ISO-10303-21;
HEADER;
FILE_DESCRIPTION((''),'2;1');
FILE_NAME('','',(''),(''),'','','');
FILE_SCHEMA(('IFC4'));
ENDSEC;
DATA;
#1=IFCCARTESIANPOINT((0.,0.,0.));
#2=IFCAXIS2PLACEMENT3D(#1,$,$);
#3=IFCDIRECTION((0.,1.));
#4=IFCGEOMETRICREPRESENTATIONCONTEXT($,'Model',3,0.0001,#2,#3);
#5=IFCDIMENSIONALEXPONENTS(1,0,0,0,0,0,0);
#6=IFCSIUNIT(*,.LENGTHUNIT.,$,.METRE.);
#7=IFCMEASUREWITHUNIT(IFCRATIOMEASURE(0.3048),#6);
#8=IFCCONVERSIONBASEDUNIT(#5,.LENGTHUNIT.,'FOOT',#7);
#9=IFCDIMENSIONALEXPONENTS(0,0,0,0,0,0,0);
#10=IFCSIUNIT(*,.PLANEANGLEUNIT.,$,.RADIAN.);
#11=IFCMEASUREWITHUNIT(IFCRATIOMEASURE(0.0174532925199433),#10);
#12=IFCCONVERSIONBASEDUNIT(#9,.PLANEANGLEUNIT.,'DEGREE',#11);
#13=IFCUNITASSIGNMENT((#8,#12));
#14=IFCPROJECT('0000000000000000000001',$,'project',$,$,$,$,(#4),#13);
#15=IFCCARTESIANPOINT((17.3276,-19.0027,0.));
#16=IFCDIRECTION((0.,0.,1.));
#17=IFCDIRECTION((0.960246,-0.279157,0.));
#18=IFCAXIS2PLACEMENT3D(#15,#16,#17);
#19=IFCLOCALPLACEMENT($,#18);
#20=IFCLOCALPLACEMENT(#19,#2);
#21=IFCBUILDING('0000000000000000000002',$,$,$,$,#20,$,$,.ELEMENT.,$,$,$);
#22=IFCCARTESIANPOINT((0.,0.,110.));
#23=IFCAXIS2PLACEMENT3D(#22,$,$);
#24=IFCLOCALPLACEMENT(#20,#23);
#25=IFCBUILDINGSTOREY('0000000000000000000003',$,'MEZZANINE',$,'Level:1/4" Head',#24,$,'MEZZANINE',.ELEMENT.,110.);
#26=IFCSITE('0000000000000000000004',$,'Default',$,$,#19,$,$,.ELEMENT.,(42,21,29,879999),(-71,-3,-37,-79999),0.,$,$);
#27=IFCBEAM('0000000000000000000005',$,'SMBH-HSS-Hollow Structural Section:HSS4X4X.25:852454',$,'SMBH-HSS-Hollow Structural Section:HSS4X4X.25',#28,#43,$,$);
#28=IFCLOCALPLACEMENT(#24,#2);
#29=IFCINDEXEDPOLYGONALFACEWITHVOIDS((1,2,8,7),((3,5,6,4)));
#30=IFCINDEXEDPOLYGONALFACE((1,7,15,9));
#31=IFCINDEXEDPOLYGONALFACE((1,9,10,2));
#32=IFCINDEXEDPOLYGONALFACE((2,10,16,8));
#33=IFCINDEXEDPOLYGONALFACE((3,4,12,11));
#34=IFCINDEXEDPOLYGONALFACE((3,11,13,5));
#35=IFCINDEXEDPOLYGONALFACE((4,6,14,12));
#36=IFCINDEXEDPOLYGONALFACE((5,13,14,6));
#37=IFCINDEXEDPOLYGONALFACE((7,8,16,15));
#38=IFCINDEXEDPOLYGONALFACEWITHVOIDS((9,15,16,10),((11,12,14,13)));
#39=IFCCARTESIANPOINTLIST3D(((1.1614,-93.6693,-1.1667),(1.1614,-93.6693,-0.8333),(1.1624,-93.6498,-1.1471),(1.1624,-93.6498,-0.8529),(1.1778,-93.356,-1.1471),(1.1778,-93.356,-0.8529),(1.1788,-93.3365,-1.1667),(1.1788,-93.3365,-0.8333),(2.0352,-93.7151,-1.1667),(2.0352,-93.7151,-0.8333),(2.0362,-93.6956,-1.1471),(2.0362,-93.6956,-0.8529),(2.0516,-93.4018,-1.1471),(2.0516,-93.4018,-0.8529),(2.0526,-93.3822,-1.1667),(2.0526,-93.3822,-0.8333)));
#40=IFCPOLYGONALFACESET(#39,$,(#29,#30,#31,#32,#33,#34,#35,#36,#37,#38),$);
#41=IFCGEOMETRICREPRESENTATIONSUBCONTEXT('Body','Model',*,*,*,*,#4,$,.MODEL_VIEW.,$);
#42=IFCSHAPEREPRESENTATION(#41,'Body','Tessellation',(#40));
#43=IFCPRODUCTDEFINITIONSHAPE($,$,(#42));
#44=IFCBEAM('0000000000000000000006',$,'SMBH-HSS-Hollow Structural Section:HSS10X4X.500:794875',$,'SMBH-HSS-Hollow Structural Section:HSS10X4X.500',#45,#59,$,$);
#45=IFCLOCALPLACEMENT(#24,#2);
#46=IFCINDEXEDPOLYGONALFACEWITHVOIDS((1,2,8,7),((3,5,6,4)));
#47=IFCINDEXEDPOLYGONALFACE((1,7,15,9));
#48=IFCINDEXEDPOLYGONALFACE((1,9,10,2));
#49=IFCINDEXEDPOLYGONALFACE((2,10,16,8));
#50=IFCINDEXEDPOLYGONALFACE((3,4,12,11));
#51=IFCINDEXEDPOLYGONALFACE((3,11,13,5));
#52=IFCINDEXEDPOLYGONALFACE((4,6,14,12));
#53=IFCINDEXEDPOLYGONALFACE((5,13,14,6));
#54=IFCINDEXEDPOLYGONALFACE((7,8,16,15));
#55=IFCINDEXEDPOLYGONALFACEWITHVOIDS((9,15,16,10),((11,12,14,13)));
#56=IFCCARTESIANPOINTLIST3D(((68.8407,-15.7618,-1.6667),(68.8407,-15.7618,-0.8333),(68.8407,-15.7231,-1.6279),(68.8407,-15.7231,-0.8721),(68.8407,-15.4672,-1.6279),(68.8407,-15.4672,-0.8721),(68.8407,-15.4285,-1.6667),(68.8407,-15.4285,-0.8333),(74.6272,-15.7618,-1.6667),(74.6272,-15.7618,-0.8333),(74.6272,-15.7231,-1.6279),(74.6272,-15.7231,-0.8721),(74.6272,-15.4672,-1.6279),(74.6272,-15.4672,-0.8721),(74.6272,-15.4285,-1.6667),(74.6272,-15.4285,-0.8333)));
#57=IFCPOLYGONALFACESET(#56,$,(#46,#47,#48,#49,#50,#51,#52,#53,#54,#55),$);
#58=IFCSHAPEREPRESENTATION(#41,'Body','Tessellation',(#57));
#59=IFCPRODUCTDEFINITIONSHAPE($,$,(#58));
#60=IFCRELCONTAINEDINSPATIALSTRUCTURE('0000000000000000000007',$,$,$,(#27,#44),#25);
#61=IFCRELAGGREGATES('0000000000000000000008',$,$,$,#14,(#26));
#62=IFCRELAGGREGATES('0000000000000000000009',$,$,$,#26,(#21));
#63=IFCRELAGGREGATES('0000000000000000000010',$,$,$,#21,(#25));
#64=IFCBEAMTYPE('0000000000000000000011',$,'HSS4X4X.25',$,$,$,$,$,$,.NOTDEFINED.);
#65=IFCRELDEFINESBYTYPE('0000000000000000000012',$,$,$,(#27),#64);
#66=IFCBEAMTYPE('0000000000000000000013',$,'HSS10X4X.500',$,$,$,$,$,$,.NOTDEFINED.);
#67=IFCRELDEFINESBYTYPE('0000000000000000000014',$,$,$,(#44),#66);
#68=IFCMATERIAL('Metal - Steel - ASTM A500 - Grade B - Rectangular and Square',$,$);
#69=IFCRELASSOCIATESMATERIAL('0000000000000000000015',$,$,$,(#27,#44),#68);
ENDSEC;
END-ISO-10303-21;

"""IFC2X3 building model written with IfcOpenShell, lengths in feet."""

from ifc_helpers import new_model, entity, si_unit, converted_unit, direction, frame, frame_2d, origin, place, context, subcontext, project, spatial, rectangle, extrude, boolean, material, type_object, element, save


model = new_model("IFC2X3")

# Units and contexts
model_context = context("Model", 3, precision=0.0001, world=origin(), true_north=direction((0.0, 1.0)))
body_context = subcontext(model_context, "Body", "Model", "MODEL_VIEW")
ifc_project = project(units=[converted_unit("LENGTHUNIT", "FOOT", entity("IfcRatioMeasure", 0.3048), si_unit("LENGTHUNIT", "METRE"), dimensions=[1, 0, 0, 0, 0, 0, 0]), converted_unit("PLANEANGLEUNIT", "DEGREE", entity("IfcRatioMeasure", 0.0174532925199433), si_unit("PLANEANGLEUNIT", "RADIAN"), dimensions=[0, 0, 0, 0, 0, 0, 0])], contexts=[model_context])

# Site, building, storey
site_placement = place(None, frame((17.3276, -19.0027, 0.0), z_axis=(0.0, 0.0, 1.0), x_axis=(0.960246, -0.279157, 0.0)))
site = spatial("IfcSite", under=ifc_project, at=site_placement, Name="Default", CompositionType="ELEMENT", RefLatitude=(42, 21, 29, 879999), RefLongitude=(-71, -3, -37, -79999), RefElevation=0.0)
building_placement = place(site_placement, origin())
building = spatial("IfcBuilding", under=site, at=building_placement, CompositionType="ELEMENT")
storey_placement = place(building_placement, frame((0.0, 0.0, 110.0)))
storey = spatial("IfcBuildingStorey", under=building, at=storey_placement, Name="MEZZANINE", ObjectType="Level:1/4\" Head", LongName="MEZZANINE", CompositionType="ELEMENT", Elevation=110.0)

# Shared definitions
ifc_material_1 = material(Name="Metal - Steel - ASTM A500 - Grade B - Rectangular and Square")

# Beams
beam_type_1 = type_object("IfcBeamType", Name="HSS4X4X.25", PredefinedType="NOTDEFINED")
beam_1_placement = place(storey_placement, frame((0.8788, -93.4876, -0.8333), z_axis=(0.0, 0.0, 1.0), x_axis=(0.99863, -0.052336, 0.0)))
element("IfcBeam", 1, at=beam_1_placement, inside=storey, type_object=beam_type_1, material=ifc_material_1, Name="SMBH-HSS-Hollow Structural Section:HSS4X4X.25:852454", ObjectType="SMBH-HSS-Hollow Structural Section:HSS4X4X.25", context=body_context, shape_type="SweptSolid", body=[
    boolean("DIFFERENCE", extrude(rectangle(XDim=0.3333, YDim=0.3333, at=frame_2d((0.0, 0.0), x_axis=(1.0, 0.0))), frame((0.2917, 0.0, -0.1667), z_axis=(1.0, 0.0, 0.0), x_axis=(0.0, 0.0, -1.0)), (0.0, 0.0, 1.0), 0.875), extrude(rectangle(XDim=0.2943, YDim=0.2943, at=frame_2d((0.0, 0.0), x_axis=(0.0, 1.0))), frame((1.1667, 0.0, -0.1667), z_axis=(-1.0, 0.0, 0.0), x_axis=(0.0, 1.0, 0.0)), (0.0, 0.0, 1.0), 0.875)),
])
beam_type_2 = type_object("IfcBeamType", Name="HSS10X4X.500", PredefinedType="NOTDEFINED")
beam_2_placement = place(storey_placement, frame((68.549, -15.5951, -0.8333)))
element("IfcBeam", 2, at=beam_2_placement, inside=storey, type_object=beam_type_2, material=ifc_material_1, Name="SMBH-HSS-Hollow Structural Section:HSS10X4X.500:794875", ObjectType="SMBH-HSS-Hollow Structural Section:HSS10X4X.500", context=body_context, shape_type="SweptSolid", body=[
    boolean("DIFFERENCE", extrude(rectangle(XDim=0.8333, YDim=0.3333, at=frame_2d((0.0, 0.0), x_axis=(1.0, 0.0))), frame((0.2917, 0.0, -0.4167), z_axis=(1.0, 0.0, 0.0), x_axis=(0.0, 0.0, -1.0)), (0.0, 0.0, 1.0), 5.7865), extrude(rectangle(XDim=0.7559, YDim=0.2559, at=frame_2d((0.0, 0.0), x_axis=(0.0, 1.0))), frame((6.0781, 0.0, -0.4167), z_axis=(-1.0, 0.0, 0.0), x_axis=(0.0, 1.0, 0.0)), (0.0, 0.0, 1.0), 5.7865)),
])

save(model, "model.ifc")
